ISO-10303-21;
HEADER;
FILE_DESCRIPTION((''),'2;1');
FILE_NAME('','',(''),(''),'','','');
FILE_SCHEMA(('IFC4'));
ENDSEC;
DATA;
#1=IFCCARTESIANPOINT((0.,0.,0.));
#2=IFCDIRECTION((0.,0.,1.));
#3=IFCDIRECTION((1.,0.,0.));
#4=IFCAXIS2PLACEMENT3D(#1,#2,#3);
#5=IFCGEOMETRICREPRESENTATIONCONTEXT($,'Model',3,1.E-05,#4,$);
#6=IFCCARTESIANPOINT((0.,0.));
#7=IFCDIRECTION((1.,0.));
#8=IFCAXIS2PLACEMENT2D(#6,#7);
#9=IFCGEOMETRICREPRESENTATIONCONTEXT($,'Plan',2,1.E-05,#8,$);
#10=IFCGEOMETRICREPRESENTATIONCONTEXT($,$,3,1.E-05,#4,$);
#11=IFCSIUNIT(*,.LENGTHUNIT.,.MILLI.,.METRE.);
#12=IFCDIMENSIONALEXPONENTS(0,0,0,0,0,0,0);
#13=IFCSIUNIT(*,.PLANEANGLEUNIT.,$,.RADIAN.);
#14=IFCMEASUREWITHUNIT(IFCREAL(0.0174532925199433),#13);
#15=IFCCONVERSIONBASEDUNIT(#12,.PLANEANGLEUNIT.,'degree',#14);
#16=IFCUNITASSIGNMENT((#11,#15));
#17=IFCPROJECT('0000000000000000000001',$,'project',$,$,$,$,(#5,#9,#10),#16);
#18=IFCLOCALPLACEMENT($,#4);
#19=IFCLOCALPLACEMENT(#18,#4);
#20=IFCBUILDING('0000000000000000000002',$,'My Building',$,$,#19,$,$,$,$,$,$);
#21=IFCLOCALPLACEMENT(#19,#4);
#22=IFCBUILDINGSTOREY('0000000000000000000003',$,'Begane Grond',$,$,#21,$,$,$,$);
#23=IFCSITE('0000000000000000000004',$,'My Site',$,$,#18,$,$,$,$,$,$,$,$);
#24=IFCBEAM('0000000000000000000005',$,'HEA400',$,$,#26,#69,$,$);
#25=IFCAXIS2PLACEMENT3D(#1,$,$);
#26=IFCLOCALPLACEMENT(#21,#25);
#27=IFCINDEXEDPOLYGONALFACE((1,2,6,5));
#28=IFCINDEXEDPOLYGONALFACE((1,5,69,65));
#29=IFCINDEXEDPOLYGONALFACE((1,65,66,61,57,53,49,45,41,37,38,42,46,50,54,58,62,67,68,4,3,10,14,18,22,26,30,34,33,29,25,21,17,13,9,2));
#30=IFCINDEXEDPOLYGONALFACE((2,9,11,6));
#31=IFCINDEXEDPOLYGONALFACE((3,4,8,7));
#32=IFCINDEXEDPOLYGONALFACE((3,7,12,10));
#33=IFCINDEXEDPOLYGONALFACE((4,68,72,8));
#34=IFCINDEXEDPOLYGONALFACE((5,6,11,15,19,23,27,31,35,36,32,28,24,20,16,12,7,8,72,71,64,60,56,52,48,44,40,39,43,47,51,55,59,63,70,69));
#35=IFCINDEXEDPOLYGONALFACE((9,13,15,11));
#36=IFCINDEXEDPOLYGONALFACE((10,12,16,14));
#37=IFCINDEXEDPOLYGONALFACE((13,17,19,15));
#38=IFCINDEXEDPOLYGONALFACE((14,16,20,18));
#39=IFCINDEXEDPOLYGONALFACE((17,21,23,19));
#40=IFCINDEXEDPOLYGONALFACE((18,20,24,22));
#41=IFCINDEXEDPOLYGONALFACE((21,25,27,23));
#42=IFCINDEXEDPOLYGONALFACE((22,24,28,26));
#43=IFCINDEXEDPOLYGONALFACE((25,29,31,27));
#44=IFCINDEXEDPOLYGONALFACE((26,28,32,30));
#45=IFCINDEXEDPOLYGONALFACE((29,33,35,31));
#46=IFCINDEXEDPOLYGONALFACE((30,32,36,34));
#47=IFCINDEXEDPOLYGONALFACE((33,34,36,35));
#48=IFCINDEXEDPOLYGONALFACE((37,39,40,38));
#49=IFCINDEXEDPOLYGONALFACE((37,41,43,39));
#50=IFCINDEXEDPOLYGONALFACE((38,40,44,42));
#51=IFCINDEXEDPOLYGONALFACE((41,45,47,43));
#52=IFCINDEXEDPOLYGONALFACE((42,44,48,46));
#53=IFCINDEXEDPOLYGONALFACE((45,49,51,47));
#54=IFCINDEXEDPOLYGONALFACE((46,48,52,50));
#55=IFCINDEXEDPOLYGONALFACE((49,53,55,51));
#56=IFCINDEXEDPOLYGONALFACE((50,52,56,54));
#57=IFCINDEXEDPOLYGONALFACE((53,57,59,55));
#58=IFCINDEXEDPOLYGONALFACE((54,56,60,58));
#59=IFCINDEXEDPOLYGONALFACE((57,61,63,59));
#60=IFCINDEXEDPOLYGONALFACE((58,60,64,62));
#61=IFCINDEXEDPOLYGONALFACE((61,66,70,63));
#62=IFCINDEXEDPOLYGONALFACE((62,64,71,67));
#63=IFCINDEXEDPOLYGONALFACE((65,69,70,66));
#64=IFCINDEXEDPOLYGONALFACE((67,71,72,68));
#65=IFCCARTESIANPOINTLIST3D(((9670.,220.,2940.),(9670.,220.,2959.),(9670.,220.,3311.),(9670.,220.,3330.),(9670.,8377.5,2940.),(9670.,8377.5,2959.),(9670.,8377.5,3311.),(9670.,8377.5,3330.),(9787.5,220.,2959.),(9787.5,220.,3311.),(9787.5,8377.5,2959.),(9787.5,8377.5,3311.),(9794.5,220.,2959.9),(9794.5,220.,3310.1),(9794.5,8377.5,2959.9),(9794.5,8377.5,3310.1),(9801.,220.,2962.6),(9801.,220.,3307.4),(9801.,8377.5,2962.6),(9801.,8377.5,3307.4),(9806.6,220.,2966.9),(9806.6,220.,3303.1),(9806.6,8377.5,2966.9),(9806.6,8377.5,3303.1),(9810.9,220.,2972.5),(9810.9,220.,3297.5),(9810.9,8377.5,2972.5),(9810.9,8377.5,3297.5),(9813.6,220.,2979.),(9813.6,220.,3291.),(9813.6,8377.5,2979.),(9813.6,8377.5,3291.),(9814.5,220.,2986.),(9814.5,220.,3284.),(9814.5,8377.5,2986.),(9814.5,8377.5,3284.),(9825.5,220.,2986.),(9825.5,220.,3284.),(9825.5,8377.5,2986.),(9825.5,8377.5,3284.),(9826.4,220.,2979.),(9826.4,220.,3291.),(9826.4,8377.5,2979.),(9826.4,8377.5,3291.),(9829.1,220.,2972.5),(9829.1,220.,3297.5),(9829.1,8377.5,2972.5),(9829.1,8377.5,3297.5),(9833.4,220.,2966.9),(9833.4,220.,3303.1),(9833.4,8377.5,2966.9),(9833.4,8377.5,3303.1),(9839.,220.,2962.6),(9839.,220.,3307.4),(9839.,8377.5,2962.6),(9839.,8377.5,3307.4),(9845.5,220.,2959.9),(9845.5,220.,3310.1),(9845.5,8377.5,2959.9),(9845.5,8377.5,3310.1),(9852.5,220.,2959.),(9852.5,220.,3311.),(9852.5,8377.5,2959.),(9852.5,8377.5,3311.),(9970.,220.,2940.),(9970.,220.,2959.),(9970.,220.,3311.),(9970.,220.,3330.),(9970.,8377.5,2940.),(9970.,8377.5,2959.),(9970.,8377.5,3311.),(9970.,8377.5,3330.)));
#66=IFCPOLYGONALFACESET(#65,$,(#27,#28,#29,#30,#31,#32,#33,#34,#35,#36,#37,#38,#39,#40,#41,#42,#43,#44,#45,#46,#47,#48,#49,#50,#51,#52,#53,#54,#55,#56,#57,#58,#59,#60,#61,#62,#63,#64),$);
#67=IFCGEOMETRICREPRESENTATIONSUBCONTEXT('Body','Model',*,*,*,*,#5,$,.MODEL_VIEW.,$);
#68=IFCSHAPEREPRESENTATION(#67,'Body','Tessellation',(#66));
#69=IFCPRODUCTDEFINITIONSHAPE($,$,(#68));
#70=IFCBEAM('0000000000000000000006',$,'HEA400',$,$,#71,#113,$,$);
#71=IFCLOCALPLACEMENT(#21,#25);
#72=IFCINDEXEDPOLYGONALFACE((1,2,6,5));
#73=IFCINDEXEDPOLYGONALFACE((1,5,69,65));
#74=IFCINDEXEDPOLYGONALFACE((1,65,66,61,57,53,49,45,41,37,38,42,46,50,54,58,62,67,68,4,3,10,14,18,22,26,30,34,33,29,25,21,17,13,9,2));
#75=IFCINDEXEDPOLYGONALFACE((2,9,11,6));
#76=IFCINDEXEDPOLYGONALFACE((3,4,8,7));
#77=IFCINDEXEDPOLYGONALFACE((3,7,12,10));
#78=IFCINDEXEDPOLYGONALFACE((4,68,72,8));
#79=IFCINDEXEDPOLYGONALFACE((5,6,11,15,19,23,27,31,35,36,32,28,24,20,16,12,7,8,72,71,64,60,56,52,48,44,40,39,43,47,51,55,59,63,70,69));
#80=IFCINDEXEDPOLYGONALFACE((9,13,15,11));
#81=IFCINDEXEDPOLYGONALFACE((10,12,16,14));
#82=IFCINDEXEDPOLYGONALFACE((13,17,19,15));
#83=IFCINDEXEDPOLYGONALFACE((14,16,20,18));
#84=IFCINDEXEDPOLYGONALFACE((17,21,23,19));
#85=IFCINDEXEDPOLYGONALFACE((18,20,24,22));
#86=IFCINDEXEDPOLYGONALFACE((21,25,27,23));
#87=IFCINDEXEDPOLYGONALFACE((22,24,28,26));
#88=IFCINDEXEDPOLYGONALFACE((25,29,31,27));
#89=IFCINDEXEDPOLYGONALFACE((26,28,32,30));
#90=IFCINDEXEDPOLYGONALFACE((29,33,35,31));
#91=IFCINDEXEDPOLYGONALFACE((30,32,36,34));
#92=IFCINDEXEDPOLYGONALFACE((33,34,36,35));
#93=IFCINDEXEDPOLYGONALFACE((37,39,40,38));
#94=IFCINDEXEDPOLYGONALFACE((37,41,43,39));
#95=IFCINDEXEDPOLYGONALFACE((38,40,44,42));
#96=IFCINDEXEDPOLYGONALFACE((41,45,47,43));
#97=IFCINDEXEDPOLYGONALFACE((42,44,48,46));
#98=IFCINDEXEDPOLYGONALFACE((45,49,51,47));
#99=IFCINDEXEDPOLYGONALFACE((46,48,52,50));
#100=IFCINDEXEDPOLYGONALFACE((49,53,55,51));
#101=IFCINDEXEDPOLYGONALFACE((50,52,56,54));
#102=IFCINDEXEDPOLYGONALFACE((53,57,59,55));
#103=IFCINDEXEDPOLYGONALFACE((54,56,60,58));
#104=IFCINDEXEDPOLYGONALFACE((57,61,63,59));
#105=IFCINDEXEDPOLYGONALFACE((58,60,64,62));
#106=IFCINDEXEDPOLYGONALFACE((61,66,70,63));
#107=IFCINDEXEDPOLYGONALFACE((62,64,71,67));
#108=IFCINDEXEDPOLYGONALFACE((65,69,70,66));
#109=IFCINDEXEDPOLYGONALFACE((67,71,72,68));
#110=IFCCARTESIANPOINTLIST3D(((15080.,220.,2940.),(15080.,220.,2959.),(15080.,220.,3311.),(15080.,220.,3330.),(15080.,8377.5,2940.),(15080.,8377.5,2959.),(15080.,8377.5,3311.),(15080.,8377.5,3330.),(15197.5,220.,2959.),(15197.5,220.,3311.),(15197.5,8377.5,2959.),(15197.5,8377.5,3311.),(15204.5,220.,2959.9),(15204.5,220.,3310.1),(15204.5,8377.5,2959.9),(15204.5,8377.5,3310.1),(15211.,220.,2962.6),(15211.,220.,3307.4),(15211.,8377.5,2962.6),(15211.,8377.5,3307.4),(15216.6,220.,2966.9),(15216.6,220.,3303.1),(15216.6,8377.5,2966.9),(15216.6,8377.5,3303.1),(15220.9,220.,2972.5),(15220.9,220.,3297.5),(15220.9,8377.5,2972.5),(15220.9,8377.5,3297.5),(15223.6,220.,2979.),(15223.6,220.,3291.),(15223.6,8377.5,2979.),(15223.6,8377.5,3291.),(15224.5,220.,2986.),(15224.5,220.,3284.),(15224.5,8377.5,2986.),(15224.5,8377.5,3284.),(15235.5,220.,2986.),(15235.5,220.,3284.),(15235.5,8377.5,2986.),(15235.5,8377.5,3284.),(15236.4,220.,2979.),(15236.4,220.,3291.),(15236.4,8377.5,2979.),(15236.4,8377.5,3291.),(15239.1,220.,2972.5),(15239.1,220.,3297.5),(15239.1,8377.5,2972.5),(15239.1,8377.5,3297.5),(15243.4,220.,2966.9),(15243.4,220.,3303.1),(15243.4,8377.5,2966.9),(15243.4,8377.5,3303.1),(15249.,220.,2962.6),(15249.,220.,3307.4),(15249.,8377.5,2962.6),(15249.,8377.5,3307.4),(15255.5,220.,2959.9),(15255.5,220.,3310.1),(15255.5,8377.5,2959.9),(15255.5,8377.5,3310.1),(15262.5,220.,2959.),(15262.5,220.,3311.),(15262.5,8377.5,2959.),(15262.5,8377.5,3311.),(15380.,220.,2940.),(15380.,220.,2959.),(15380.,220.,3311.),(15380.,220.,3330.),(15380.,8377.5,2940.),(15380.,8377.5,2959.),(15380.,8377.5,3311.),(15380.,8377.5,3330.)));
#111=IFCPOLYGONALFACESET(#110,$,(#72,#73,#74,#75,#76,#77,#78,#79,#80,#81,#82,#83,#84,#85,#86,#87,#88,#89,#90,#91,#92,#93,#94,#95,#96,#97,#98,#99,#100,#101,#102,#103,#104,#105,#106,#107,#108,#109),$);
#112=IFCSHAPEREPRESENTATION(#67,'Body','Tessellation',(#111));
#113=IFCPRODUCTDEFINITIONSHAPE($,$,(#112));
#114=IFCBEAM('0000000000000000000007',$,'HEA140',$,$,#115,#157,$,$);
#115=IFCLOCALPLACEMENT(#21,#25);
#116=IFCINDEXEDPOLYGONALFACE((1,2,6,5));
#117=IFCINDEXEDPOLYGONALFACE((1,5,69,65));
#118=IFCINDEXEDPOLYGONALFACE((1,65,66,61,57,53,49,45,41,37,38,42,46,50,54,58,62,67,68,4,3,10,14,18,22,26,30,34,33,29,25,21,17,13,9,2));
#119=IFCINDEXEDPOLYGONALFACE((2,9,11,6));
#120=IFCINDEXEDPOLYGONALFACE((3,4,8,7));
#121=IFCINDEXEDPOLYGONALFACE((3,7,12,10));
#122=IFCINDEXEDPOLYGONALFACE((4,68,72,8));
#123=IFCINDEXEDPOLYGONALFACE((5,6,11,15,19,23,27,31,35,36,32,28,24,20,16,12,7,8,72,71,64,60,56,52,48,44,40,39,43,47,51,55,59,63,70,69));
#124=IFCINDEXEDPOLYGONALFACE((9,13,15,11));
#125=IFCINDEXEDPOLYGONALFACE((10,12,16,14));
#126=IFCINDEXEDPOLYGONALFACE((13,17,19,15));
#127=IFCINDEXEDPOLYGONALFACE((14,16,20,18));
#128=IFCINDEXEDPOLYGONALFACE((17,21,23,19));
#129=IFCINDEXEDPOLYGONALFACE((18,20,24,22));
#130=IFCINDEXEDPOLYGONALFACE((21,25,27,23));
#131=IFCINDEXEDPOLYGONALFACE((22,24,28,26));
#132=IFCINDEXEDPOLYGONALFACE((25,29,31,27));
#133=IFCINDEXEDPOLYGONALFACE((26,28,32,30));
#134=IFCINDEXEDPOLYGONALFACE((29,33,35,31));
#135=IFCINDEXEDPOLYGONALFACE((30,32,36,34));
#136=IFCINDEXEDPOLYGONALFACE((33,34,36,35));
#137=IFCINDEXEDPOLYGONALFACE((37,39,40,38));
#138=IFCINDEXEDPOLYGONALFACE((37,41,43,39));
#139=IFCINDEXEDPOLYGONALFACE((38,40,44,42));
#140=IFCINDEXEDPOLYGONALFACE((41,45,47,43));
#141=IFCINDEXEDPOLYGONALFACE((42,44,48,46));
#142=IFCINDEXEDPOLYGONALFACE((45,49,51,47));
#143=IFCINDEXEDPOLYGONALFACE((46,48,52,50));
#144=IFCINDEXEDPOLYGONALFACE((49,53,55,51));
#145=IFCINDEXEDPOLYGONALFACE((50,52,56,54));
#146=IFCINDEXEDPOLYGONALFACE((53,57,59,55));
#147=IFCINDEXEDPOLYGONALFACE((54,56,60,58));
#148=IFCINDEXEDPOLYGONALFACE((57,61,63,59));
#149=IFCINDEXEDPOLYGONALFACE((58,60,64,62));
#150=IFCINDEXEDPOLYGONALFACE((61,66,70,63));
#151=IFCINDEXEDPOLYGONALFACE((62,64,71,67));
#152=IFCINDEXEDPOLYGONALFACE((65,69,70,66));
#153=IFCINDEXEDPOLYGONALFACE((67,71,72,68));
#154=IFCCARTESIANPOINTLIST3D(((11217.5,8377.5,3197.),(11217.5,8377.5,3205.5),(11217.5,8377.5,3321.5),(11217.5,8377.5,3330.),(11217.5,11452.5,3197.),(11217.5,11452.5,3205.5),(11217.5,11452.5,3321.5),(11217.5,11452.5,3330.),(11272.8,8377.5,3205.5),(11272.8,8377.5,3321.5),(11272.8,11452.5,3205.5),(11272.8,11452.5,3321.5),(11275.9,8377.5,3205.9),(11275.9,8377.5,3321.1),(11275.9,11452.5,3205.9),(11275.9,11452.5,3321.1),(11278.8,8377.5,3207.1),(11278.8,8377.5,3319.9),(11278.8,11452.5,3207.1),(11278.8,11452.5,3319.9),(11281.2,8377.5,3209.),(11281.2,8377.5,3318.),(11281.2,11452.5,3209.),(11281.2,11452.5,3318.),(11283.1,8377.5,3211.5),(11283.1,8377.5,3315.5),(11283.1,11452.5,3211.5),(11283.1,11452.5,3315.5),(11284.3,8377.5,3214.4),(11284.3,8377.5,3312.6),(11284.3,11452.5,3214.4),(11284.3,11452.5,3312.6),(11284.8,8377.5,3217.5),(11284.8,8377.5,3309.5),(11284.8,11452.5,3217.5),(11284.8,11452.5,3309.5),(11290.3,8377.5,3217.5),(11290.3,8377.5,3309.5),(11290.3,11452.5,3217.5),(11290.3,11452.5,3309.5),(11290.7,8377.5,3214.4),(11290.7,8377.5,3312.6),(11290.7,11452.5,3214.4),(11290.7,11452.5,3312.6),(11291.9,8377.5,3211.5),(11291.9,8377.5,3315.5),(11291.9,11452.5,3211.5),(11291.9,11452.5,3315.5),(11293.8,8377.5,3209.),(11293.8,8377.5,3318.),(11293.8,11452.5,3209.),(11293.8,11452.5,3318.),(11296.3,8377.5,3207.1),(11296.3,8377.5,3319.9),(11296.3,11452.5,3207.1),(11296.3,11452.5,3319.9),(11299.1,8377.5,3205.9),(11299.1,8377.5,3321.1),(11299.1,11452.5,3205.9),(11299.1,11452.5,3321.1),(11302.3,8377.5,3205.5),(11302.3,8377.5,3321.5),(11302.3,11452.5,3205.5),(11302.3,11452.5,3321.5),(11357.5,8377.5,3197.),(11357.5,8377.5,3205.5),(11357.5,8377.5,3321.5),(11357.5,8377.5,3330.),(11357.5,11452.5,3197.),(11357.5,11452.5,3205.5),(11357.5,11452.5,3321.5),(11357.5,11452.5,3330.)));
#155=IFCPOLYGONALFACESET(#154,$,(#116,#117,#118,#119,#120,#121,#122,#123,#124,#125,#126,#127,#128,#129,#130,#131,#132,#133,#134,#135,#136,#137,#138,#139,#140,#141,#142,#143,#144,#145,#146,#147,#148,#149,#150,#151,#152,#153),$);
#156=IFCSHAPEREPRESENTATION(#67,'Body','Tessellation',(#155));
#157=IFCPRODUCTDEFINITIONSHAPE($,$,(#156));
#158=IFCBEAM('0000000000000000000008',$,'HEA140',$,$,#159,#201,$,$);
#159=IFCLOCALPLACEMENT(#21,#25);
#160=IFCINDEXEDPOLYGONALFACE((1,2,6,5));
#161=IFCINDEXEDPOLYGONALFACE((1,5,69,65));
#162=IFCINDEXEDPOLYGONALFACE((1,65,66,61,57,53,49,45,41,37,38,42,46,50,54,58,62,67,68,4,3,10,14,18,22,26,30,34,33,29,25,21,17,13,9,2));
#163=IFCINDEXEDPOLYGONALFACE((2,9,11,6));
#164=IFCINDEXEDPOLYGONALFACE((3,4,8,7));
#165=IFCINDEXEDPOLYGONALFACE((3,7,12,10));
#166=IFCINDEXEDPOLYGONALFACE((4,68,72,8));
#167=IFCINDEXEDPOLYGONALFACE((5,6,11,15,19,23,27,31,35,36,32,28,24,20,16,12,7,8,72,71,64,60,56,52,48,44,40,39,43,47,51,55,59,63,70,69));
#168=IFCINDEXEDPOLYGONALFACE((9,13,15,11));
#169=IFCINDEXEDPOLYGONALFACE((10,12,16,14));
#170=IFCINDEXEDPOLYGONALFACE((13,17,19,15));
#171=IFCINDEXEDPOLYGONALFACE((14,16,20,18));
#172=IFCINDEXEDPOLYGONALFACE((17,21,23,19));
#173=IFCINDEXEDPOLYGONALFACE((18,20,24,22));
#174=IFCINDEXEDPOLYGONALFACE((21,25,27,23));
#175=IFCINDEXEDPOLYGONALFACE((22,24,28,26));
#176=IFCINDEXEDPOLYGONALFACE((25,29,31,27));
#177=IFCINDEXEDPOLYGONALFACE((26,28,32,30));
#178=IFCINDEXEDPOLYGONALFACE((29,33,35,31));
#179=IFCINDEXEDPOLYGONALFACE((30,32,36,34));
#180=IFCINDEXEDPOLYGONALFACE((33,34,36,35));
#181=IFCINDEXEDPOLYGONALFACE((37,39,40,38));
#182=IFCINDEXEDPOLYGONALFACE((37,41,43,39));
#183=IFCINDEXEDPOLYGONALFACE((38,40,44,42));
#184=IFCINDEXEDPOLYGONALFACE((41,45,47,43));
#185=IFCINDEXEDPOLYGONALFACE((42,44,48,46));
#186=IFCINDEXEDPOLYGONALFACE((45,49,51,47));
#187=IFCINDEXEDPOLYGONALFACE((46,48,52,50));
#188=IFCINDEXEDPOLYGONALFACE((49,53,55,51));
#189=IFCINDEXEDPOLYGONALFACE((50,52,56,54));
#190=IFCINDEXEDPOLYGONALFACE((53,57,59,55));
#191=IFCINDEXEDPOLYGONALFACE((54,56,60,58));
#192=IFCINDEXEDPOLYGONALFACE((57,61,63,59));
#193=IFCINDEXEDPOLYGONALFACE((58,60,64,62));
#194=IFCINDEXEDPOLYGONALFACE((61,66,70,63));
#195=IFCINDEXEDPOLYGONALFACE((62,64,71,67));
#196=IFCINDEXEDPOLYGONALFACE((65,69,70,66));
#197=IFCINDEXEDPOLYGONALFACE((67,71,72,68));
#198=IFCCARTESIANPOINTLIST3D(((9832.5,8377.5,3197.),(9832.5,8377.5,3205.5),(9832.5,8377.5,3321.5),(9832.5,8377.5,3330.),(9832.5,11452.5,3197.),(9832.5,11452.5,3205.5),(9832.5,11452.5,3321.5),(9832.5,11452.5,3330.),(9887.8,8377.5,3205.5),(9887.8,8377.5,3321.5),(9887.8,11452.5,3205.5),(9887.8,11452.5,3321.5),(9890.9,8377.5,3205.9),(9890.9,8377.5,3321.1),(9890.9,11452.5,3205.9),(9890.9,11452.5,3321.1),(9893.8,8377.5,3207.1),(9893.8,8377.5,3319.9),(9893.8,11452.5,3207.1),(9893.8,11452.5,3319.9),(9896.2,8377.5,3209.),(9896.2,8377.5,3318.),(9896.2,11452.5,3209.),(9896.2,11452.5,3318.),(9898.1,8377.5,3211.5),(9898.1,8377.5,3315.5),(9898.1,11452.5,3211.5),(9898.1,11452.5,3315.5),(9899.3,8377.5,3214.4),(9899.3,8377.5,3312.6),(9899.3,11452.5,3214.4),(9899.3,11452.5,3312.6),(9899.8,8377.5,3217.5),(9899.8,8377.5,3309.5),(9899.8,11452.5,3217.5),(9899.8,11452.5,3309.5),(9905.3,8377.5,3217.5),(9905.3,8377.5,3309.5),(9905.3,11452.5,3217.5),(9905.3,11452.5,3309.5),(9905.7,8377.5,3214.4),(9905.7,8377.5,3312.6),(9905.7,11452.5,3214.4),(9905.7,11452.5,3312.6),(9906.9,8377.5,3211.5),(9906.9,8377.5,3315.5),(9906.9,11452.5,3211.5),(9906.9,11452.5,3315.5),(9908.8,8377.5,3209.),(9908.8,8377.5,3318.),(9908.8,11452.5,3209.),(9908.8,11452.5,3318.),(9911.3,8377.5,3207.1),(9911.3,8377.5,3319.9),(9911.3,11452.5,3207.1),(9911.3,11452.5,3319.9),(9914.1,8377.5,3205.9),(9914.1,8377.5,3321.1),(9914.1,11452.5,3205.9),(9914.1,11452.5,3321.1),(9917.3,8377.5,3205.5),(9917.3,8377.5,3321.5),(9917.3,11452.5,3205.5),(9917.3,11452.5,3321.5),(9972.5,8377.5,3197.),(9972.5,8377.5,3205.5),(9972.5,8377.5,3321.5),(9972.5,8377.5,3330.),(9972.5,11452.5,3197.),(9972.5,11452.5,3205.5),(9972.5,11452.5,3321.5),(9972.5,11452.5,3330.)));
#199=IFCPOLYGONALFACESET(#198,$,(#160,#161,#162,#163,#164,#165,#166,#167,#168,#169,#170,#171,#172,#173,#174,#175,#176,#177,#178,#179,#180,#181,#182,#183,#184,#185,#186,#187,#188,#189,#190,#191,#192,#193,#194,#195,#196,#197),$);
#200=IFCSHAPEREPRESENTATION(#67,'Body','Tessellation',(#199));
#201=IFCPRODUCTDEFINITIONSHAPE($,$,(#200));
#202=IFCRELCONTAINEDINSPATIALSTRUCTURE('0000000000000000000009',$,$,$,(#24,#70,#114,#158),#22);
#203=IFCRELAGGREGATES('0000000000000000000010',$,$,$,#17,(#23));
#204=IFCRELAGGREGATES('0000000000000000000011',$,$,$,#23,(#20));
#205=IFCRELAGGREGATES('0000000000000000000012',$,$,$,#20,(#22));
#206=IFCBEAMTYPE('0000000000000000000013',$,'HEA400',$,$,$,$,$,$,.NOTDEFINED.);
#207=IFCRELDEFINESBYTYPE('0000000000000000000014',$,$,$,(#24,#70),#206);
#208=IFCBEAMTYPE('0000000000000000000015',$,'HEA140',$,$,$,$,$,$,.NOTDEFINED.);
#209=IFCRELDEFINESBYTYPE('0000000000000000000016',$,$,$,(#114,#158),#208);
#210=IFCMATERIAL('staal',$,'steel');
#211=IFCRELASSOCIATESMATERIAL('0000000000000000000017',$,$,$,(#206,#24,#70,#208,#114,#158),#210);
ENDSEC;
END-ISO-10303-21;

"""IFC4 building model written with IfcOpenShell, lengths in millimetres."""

from ifc_helpers import new_model, entity, si_unit, converted_unit, frame, origin_with_axes, origin_2d_with_axis, place, context, subcontext, project, spatial, i_section, extrude, material, material_profile, profile_set, profile_usage, type_object, element, save


model = new_model("IFC4")

# Units and contexts
model_context = context("Model", 3, precision=1e-05, world=origin_with_axes())
plan_context = context("Plan", 2, precision=1e-05, world=origin_2d_with_axis())
context_of_model = context(None, 3, precision=1e-05, world=origin_with_axes())
body_context = subcontext(model_context, "Body", "Model", "MODEL_VIEW")
ifc_project = project(units=[si_unit("LENGTHUNIT", "METRE", prefix="MILLI"), converted_unit("PLANEANGLEUNIT", "degree", entity("IfcReal", 0.0174532925199433), si_unit("PLANEANGLEUNIT", "RADIAN"), dimensions=[0, 0, 0, 0, 0, 0, 0])], contexts=[model_context, plan_context, context_of_model])

# Site, building, storey
site_placement = place(None, origin_with_axes())
site = spatial("IfcSite", under=ifc_project, at=site_placement, Name="My Site")
building_placement = place(site_placement, origin_with_axes())
building = spatial("IfcBuilding", under=site, at=building_placement, Name="My Building")
storey_placement = place(building_placement, origin_with_axes())
storey = spatial("IfcBuildingStorey", under=building, at=storey_placement, Name="Begane Grond")

# Shared definitions
ifc_material = material(Name="staal", Category="steel")

# Beams
ifc_material_profile_1 = material_profile(ifc_material, i_section(OverallWidth=300.0, OverallDepth=390.0, WebThickness=11.0, FlangeThickness=19.0, FilletRadius=27.0))
ifc_profile_set_1 = profile_set([ifc_material_profile_1], Name="HEA400")
ifc_profile_usage_1 = profile_usage(ifc_profile_set_1, cardinal=5)
beam_type_1 = type_object("IfcBeamType", Name="HEA400", PredefinedType="NOTDEFINED", material=ifc_profile_set_1)
beam_1_placement = place(storey_placement, frame((9820.0, 220.0, 3135.0), z_axis=(0.0, 1.0, 0.0), x_axis=(-1.0, 0.0, 0.0)))
element("IfcBeam", 1, at=beam_1_placement, inside=storey, type_object=beam_type_1, material=ifc_profile_usage_1, Name="HEA400", context=body_context, shape_type="SweptSolid", body=[
    extrude(i_section(OverallWidth=300.0, OverallDepth=390.0, WebThickness=11.0, FlangeThickness=19.0, FilletRadius=27.0), origin_with_axes(), (0.0, 0.0, 1.0), 8157.5),
])
ifc_profile_usage_2 = profile_usage(ifc_profile_set_1, cardinal=5)
beam_2_placement = place(storey_placement, frame((15230.0, 220.0, 3135.0), z_axis=(0.0, 1.0, 0.0), x_axis=(-1.0, 0.0, 0.0)))
element("IfcBeam", 2, at=beam_2_placement, inside=storey, type_object=beam_type_1, material=ifc_profile_usage_2, Name="HEA400", context=body_context, shape_type="SweptSolid", body=[
    extrude(i_section(OverallWidth=300.0, OverallDepth=390.0, WebThickness=11.0, FlangeThickness=19.0, FilletRadius=27.0), origin_with_axes(), (0.0, 0.0, 1.0), 8157.5),
])
ifc_material_profile_2 = material_profile(ifc_material, i_section(OverallWidth=140.0, OverallDepth=133.0, WebThickness=5.5, FlangeThickness=8.5, FilletRadius=12.0))
ifc_profile_set_2 = profile_set([ifc_material_profile_2], Name="HEA140")
ifc_profile_usage_3 = profile_usage(ifc_profile_set_2)
beam_type_2 = type_object("IfcBeamType", Name="HEA140", PredefinedType="NOTDEFINED", material=ifc_profile_set_2)
beam_3_placement = place(storey_placement, frame((11287.5, 8377.5, 3263.5), z_axis=(0.0, 1.0, 0.0), x_axis=(-1.0, 0.0, 0.0)))
element("IfcBeam", 3, at=beam_3_placement, inside=storey, type_object=beam_type_2, material=ifc_profile_usage_3, Name="HEA140", context=body_context, shape_type="SweptSolid", body=[
    extrude(i_section(OverallWidth=140.0, OverallDepth=133.0, WebThickness=5.5, FlangeThickness=8.5, FilletRadius=12.0), origin_with_axes(), (0.0, 0.0, 1.0), 3075.0),
])
ifc_profile_usage_4 = profile_usage(ifc_profile_set_2)
beam_4_placement = place(storey_placement, frame((9902.5, 8377.5, 3263.5), z_axis=(0.0, 1.0, 0.0), x_axis=(-1.0, 0.0, 0.0)))
element("IfcBeam", 4, at=beam_4_placement, inside=storey, type_object=beam_type_2, material=ifc_profile_usage_4, Name="HEA140", context=body_context, shape_type="SweptSolid", body=[
    extrude(i_section(OverallWidth=140.0, OverallDepth=133.0, WebThickness=5.5, FlangeThickness=8.5, FilletRadius=12.0), origin_with_axes(), (0.0, 0.0, 1.0), 3075.0),
])

save(model, "model.ifc")
